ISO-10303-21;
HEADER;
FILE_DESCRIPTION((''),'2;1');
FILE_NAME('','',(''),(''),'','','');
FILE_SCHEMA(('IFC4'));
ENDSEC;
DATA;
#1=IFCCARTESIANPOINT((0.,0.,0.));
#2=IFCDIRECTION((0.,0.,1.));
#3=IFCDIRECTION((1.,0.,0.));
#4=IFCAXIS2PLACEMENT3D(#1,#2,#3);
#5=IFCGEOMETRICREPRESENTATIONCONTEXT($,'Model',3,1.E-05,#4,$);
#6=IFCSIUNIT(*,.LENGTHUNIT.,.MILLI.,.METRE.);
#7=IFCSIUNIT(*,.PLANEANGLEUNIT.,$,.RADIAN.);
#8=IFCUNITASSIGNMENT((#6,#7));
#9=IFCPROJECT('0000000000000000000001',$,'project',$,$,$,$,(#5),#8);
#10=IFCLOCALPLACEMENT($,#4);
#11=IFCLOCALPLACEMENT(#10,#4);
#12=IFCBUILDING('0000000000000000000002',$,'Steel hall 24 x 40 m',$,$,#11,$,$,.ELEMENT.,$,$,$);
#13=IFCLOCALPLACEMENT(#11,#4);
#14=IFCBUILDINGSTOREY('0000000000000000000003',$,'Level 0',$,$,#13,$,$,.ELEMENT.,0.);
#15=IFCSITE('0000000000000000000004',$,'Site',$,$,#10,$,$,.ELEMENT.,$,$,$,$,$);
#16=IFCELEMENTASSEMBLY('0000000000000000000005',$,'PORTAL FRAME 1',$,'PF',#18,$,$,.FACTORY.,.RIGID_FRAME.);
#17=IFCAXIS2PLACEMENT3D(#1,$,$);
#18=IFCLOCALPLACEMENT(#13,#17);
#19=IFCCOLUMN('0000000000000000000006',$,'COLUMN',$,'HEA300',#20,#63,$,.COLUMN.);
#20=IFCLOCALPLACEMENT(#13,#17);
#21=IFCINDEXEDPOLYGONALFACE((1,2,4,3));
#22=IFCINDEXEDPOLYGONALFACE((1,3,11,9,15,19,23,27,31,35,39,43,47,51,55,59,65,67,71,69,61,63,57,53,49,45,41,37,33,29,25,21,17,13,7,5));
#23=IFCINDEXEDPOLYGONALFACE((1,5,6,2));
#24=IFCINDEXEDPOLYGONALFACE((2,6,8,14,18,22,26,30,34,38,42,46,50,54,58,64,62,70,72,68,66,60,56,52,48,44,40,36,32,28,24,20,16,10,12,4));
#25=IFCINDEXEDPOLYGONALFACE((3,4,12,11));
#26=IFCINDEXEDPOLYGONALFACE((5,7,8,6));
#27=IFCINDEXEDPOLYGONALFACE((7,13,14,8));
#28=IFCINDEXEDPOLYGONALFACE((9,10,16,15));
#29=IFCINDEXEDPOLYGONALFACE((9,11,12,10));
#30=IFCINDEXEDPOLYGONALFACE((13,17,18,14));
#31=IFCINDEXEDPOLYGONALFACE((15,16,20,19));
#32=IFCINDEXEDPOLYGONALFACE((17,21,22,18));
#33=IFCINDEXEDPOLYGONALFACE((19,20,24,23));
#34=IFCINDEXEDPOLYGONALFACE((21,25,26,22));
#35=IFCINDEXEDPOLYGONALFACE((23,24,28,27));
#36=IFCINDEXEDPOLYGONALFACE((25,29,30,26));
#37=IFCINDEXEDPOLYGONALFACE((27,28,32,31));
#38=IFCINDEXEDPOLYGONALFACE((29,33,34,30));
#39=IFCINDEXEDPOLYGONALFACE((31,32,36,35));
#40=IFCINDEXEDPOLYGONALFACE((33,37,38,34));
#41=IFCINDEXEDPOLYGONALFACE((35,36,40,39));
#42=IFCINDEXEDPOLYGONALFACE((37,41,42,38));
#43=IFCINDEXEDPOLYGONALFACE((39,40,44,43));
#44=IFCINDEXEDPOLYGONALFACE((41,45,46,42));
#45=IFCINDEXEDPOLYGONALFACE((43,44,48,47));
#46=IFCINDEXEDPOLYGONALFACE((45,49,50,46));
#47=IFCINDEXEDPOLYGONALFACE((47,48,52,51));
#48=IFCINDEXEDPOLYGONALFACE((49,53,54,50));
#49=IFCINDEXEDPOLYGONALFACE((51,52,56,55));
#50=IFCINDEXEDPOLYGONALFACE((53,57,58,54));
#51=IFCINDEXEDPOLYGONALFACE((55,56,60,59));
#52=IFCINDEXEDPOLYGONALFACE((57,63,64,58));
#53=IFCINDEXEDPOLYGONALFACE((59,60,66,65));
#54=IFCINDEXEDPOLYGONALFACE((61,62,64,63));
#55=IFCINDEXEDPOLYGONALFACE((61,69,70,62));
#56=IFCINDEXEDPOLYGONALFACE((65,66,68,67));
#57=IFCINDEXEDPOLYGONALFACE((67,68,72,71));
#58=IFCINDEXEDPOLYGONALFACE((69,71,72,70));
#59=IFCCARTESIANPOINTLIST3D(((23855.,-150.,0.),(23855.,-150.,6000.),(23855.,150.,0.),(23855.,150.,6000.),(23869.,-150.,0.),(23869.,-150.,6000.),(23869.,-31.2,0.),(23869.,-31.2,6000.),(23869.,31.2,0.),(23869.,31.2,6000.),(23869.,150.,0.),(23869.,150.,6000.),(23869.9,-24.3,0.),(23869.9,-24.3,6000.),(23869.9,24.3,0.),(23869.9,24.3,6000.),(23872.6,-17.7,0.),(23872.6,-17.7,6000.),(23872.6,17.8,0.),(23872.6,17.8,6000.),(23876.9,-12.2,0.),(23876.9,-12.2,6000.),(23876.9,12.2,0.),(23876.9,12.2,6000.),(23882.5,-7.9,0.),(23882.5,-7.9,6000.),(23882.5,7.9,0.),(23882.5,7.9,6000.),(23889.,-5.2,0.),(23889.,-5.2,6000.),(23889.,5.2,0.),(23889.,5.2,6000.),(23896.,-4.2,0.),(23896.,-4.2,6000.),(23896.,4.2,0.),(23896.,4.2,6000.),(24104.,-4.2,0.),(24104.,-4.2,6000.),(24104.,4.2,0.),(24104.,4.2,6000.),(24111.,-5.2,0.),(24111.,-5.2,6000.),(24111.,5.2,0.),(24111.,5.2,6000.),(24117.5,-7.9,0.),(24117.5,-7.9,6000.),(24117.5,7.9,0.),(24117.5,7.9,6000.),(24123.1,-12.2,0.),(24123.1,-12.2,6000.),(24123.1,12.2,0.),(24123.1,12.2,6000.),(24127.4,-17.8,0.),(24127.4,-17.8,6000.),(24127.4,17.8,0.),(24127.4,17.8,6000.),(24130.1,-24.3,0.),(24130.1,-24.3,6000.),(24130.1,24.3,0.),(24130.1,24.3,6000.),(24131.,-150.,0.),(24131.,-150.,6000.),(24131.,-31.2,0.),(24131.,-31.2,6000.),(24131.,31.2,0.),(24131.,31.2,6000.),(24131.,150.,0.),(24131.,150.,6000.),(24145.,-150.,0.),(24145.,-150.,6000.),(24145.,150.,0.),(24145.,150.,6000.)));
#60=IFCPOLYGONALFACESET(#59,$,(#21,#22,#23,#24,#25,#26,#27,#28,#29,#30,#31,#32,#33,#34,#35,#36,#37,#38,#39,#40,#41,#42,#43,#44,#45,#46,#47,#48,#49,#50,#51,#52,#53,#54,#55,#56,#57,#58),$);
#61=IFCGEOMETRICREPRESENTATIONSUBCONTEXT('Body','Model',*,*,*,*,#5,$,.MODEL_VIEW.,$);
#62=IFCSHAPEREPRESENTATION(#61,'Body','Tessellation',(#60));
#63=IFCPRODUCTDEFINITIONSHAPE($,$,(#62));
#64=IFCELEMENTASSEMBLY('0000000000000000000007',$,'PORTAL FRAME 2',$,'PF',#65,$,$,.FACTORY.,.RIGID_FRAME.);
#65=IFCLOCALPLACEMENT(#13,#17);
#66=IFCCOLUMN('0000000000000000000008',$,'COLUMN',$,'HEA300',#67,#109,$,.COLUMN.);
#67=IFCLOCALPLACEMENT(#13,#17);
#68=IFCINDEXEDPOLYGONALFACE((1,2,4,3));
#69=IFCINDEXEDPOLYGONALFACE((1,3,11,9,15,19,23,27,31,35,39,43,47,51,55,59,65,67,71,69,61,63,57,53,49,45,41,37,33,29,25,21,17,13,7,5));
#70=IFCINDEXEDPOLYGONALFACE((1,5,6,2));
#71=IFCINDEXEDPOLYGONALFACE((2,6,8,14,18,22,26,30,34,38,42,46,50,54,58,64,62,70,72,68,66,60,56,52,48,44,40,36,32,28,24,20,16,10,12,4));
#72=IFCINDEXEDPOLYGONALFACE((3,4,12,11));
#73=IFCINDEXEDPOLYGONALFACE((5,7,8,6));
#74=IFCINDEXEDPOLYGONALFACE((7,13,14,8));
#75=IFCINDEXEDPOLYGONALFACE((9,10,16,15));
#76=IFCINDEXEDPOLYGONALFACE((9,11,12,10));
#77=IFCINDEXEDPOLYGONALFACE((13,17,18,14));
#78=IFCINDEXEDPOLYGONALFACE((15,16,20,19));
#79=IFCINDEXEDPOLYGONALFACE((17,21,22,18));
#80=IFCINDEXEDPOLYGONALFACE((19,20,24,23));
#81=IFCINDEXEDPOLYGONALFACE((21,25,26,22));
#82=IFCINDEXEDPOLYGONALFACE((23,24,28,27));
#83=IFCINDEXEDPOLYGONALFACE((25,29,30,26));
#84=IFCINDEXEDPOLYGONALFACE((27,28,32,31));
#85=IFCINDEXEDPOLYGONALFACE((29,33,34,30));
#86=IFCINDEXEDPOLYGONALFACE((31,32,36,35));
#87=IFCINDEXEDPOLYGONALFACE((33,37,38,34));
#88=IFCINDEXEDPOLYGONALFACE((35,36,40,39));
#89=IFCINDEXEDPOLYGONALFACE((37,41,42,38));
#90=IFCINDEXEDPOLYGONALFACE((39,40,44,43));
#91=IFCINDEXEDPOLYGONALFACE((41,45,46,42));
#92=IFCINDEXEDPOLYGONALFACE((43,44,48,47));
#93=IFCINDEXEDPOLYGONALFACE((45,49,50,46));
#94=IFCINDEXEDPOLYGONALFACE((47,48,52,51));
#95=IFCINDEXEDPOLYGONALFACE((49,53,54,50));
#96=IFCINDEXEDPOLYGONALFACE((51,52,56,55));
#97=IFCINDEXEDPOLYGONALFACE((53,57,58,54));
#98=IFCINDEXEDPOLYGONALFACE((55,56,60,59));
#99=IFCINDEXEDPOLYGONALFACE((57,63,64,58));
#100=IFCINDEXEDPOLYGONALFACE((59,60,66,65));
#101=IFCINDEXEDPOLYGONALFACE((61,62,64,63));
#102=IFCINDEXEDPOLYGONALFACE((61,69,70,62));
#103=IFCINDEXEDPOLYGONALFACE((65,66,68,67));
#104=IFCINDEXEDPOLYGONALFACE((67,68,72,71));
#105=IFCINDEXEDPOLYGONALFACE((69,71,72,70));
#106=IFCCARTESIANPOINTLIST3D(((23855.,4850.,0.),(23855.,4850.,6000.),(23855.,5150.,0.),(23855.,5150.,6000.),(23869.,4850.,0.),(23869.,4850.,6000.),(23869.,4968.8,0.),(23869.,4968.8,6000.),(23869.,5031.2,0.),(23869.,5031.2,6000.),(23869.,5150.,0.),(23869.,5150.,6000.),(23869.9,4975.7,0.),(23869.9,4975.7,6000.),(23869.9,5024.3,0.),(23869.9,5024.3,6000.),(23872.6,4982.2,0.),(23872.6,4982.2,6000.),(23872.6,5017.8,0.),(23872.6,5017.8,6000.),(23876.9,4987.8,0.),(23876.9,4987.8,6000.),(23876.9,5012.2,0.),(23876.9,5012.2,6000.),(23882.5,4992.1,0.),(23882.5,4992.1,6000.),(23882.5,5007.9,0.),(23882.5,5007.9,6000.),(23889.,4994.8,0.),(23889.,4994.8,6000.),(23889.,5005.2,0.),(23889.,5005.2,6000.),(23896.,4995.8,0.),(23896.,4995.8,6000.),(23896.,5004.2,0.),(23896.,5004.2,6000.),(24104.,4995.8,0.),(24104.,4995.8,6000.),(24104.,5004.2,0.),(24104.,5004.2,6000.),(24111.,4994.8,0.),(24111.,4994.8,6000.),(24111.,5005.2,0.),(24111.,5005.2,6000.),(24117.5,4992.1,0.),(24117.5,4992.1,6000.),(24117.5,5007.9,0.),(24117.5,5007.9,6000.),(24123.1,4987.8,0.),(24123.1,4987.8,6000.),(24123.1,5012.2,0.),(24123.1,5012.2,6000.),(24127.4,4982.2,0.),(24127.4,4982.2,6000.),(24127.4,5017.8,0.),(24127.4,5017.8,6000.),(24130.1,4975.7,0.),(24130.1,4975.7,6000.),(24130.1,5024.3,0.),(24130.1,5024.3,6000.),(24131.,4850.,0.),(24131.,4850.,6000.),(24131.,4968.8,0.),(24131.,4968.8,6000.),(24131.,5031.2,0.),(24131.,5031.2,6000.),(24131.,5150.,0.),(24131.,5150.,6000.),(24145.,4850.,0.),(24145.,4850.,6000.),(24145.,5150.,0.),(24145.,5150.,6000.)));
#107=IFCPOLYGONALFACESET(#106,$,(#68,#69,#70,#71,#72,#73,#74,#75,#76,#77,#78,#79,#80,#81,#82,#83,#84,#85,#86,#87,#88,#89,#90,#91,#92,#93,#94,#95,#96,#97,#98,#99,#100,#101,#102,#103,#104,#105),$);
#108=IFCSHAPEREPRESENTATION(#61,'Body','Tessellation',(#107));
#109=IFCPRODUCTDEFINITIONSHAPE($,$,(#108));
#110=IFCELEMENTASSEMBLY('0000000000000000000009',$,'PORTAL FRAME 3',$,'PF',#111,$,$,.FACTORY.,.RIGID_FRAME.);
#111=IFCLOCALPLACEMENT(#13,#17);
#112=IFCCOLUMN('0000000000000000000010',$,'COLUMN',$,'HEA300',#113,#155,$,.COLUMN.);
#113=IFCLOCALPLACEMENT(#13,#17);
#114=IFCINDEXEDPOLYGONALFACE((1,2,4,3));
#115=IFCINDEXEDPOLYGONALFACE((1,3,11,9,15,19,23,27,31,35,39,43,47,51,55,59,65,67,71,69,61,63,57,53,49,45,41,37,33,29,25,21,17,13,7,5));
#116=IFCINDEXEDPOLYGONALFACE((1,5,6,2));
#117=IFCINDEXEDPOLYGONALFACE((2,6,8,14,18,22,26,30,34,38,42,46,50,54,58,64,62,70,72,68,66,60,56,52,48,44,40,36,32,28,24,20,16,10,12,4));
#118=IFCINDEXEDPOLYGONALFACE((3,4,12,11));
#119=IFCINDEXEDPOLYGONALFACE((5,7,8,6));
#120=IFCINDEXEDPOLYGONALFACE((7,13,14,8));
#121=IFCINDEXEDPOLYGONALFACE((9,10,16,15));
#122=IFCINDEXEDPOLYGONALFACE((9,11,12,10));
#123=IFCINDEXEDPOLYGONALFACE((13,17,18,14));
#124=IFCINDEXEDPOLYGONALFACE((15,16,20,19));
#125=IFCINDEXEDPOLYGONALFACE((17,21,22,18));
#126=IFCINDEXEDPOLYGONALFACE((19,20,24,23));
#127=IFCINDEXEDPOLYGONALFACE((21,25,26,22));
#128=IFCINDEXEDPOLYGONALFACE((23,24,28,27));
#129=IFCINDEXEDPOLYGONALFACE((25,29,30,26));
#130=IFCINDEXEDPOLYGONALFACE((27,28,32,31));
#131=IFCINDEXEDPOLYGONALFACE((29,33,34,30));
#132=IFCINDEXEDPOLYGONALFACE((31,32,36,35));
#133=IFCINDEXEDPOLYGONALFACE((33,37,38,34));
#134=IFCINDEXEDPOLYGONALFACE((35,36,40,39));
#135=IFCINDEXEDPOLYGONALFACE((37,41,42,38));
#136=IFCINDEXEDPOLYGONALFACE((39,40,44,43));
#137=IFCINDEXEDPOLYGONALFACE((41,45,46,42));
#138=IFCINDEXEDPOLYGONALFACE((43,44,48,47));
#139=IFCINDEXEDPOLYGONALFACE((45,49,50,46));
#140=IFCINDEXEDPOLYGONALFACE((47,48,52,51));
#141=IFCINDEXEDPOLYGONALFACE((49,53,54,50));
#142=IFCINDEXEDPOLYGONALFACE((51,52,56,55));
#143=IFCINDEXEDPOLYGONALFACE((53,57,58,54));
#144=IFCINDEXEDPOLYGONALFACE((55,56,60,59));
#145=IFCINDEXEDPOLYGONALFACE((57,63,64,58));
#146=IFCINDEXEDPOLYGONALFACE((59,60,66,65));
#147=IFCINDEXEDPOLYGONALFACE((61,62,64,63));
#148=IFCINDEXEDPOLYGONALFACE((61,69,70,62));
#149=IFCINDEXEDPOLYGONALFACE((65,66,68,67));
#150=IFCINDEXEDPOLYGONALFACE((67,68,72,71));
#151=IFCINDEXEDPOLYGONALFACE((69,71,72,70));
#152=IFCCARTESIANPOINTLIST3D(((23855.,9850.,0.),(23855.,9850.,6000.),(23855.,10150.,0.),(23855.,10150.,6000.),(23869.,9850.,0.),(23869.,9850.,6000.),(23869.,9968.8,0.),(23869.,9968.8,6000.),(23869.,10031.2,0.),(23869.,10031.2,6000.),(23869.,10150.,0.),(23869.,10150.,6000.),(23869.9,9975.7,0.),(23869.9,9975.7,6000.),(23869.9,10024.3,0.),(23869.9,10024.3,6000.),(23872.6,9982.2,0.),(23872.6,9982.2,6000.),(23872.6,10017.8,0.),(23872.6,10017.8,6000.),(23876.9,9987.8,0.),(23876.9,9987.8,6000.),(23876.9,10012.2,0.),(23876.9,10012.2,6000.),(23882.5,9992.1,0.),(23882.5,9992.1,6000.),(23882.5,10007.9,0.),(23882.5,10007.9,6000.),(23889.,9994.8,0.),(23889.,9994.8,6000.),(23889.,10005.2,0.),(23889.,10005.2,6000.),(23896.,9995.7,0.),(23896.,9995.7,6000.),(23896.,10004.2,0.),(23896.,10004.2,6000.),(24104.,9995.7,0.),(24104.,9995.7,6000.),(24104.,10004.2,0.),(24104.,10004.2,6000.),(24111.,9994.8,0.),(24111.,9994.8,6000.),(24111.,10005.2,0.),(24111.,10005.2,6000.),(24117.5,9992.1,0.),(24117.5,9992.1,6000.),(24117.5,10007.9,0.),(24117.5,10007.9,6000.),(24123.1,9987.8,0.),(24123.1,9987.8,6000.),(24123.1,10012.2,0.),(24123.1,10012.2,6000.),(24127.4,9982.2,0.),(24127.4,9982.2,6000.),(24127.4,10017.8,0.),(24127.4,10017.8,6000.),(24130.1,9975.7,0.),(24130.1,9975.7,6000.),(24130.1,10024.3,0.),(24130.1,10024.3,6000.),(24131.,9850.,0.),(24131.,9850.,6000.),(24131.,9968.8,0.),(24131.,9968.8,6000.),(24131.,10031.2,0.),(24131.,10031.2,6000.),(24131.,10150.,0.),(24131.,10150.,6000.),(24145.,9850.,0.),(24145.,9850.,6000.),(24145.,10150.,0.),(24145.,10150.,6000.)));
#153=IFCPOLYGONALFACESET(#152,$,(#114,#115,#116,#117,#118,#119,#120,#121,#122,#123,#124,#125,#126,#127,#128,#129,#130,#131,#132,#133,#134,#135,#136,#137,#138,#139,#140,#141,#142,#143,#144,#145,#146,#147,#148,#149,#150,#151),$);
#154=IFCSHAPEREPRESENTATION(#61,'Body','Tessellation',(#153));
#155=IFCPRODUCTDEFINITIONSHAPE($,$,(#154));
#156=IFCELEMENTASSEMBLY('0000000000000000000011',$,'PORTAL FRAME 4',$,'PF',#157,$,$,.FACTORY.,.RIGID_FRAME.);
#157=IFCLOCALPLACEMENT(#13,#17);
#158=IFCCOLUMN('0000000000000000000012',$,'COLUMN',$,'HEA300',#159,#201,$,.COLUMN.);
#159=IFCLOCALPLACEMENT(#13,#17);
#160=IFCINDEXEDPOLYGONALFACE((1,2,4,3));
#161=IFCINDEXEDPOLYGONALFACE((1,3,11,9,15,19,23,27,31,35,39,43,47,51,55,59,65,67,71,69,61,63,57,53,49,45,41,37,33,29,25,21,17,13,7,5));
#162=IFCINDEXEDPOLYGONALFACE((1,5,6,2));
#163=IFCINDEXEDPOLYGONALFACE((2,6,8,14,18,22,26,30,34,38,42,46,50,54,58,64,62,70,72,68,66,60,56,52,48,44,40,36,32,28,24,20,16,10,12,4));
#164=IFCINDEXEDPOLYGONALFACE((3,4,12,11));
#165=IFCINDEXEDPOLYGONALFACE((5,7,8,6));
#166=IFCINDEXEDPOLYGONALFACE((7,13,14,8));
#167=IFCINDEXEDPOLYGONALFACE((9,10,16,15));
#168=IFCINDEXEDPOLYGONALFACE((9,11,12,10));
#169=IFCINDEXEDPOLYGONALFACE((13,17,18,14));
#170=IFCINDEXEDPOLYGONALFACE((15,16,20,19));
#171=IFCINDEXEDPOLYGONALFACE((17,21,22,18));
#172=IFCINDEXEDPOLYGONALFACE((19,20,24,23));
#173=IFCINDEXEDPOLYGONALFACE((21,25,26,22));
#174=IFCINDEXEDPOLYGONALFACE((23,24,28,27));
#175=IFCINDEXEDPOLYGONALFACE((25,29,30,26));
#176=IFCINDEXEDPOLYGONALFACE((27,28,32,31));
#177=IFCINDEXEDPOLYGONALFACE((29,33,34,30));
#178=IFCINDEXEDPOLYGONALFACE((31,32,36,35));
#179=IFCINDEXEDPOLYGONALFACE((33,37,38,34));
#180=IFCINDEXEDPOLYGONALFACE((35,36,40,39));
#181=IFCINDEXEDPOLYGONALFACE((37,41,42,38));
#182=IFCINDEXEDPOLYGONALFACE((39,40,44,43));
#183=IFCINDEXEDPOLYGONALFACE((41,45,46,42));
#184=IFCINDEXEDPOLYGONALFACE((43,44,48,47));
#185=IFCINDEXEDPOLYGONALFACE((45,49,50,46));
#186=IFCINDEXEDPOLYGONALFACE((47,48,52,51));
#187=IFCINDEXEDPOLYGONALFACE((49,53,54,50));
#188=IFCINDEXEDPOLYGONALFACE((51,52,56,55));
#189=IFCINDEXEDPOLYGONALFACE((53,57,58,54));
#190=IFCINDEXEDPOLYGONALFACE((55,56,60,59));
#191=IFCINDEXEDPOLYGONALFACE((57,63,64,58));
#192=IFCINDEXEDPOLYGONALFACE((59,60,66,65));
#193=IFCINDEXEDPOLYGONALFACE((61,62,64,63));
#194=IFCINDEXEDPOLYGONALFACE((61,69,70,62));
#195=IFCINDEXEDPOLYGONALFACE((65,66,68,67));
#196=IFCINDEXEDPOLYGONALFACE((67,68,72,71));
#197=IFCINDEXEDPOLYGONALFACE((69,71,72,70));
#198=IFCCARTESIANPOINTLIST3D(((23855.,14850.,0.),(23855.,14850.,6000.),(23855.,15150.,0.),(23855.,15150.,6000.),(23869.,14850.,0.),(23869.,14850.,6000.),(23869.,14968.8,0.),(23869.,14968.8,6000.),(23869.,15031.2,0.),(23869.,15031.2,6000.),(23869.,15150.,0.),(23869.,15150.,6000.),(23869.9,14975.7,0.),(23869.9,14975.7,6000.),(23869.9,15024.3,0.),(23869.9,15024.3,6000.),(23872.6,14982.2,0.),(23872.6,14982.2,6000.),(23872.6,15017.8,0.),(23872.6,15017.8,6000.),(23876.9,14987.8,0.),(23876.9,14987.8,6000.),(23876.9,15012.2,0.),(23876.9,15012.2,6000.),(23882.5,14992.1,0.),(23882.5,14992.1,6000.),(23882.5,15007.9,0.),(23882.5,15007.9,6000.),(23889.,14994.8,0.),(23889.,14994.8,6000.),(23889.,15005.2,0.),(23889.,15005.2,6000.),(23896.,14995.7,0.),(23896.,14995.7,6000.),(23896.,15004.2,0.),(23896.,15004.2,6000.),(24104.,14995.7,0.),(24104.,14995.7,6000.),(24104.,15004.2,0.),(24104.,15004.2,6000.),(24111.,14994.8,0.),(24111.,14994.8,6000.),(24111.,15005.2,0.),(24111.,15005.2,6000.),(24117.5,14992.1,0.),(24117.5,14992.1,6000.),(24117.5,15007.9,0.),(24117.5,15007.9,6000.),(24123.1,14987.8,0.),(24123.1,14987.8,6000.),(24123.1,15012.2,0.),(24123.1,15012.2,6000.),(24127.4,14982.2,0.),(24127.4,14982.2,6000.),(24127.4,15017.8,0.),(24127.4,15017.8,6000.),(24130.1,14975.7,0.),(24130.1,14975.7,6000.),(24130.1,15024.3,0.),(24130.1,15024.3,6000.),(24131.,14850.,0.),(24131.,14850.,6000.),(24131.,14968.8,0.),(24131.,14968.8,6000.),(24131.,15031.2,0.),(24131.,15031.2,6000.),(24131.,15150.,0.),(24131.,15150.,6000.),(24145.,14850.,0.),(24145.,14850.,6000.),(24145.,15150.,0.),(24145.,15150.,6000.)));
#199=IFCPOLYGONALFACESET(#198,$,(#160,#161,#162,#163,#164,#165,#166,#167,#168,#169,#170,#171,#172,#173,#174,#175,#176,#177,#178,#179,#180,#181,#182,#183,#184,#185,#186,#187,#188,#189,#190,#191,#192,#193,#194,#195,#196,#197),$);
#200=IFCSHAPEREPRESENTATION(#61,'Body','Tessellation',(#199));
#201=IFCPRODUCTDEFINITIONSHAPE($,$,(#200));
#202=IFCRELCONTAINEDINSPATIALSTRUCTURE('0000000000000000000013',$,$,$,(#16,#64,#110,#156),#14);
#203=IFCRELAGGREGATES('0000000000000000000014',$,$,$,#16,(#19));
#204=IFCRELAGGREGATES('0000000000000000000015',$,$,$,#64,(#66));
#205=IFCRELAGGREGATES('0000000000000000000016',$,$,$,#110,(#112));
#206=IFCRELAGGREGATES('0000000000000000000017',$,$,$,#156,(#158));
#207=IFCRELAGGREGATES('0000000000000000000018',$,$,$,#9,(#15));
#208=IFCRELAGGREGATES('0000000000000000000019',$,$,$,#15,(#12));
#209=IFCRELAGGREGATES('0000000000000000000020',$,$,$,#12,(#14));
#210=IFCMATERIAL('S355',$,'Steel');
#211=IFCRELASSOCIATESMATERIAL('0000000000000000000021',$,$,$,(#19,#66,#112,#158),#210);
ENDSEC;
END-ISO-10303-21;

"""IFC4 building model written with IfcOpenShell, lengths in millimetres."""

from ifc_helpers import new_model, si_unit, frame, origin_with_axes, place, context, subcontext, project, spatial, i_section, extrude, material, element, aggregate, save


model = new_model("IFC4")

# Units and contexts
model_context = context("Model", 3, precision=1e-05, world=origin_with_axes())
body_context = subcontext(model_context, "Body", "Model", "MODEL_VIEW")
ifc_project = project(units=[si_unit("LENGTHUNIT", "METRE", prefix="MILLI"), si_unit("PLANEANGLEUNIT", "RADIAN")], contexts=[model_context])

# Site, building, storey
site_placement = place(None, origin_with_axes())
site = spatial("IfcSite", under=ifc_project, at=site_placement, Name="Site", CompositionType="ELEMENT")
building_placement = place(site_placement, origin_with_axes())
building = spatial("IfcBuilding", under=site, at=building_placement, Name="Steel hall 24 x 40 m", CompositionType="ELEMENT")
storey_placement = place(building_placement, origin_with_axes())
storey = spatial("IfcBuildingStorey", under=building, at=storey_placement, Name="Level 0", CompositionType="ELEMENT", Elevation=0.0)

# Element assemblies, columns
assembly_1_placement = place(storey_placement, origin_with_axes())
assembly_1 = element("IfcElementAssembly", 1, at=assembly_1_placement, inside=storey, Name="PORTAL FRAME 1", ObjectType="PF", AssemblyPlace="FACTORY", PredefinedType="RIGID_FRAME")
ifc_material = material(Name="S355", Category="Steel")
column_1_placement = place(storey_placement, frame((24000.0, 0.0, 0.0), z_axis=(0.0, 0.0, 1.0), x_axis=(0.0, 1.0, 0.0)))
column_1 = element("IfcColumn", 2, at=column_1_placement, material=ifc_material, Name="COLUMN", ObjectType="HEA300", PredefinedType="COLUMN", context=body_context, shape_type="SweptSolid", body=[
    extrude(i_section(OverallWidth=300.0, OverallDepth=290.0, WebThickness=8.5, FlangeThickness=14.0, FilletRadius=27.0), origin_with_axes(), (0.0, 0.0, 1.0), 6000.0),
])
assembly_2_placement = place(storey_placement, frame((0.0, 5000.0, 0.0), z_axis=(0.0, 0.0, 1.0), x_axis=(1.0, 0.0, 0.0)))
assembly_2 = element("IfcElementAssembly", 3, at=assembly_2_placement, inside=storey, Name="PORTAL FRAME 2", ObjectType="PF", AssemblyPlace="FACTORY", PredefinedType="RIGID_FRAME")
column_2_placement = place(storey_placement, frame((24000.0, 5000.0, 0.0), z_axis=(0.0, 0.0, 1.0), x_axis=(0.0, 1.0, 0.0)))
column_2 = element("IfcColumn", 4, at=column_2_placement, material=ifc_material, Name="COLUMN", ObjectType="HEA300", PredefinedType="COLUMN", context=body_context, shape_type="SweptSolid", body=[
    extrude(i_section(OverallWidth=300.0, OverallDepth=290.0, WebThickness=8.5, FlangeThickness=14.0, FilletRadius=27.0), origin_with_axes(), (0.0, 0.0, 1.0), 6000.0),
])
assembly_3_placement = place(storey_placement, frame((0.0, 10000.0, 0.0), z_axis=(0.0, 0.0, 1.0), x_axis=(1.0, 0.0, 0.0)))
assembly_3 = element("IfcElementAssembly", 5, at=assembly_3_placement, inside=storey, Name="PORTAL FRAME 3", ObjectType="PF", AssemblyPlace="FACTORY", PredefinedType="RIGID_FRAME")
column_3_placement = place(storey_placement, frame((24000.0, 10000.0, 0.0), z_axis=(0.0, 0.0, 1.0), x_axis=(0.0, 1.0, 0.0)))
column_3 = element("IfcColumn", 6, at=column_3_placement, material=ifc_material, Name="COLUMN", ObjectType="HEA300", PredefinedType="COLUMN", context=body_context, shape_type="SweptSolid", body=[
    extrude(i_section(OverallWidth=300.0, OverallDepth=290.0, WebThickness=8.5, FlangeThickness=14.0, FilletRadius=27.0), origin_with_axes(), (0.0, 0.0, 1.0), 6000.0),
])
assembly_4_placement = place(storey_placement, frame((0.0, 15000.0, 0.0), z_axis=(0.0, 0.0, 1.0), x_axis=(1.0, 0.0, 0.0)))
assembly_4 = element("IfcElementAssembly", 7, at=assembly_4_placement, inside=storey, Name="PORTAL FRAME 4", ObjectType="PF", AssemblyPlace="FACTORY", PredefinedType="RIGID_FRAME")
column_4_placement = place(storey_placement, frame((24000.0, 15000.0, 0.0), z_axis=(0.0, 0.0, 1.0), x_axis=(0.0, 1.0, 0.0)))
column_4 = element("IfcColumn", 8, at=column_4_placement, material=ifc_material, Name="COLUMN", ObjectType="HEA300", PredefinedType="COLUMN", context=body_context, shape_type="SweptSolid", body=[
    extrude(i_section(OverallWidth=300.0, OverallDepth=290.0, WebThickness=8.5, FlangeThickness=14.0, FilletRadius=27.0), origin_with_axes(), (0.0, 0.0, 1.0), 6000.0),
])

aggregate(assembly_1, [column_1])
aggregate(assembly_2, [column_2])
aggregate(assembly_3, [column_3])
aggregate(assembly_4, [column_4])

save(model, "model.ifc")
